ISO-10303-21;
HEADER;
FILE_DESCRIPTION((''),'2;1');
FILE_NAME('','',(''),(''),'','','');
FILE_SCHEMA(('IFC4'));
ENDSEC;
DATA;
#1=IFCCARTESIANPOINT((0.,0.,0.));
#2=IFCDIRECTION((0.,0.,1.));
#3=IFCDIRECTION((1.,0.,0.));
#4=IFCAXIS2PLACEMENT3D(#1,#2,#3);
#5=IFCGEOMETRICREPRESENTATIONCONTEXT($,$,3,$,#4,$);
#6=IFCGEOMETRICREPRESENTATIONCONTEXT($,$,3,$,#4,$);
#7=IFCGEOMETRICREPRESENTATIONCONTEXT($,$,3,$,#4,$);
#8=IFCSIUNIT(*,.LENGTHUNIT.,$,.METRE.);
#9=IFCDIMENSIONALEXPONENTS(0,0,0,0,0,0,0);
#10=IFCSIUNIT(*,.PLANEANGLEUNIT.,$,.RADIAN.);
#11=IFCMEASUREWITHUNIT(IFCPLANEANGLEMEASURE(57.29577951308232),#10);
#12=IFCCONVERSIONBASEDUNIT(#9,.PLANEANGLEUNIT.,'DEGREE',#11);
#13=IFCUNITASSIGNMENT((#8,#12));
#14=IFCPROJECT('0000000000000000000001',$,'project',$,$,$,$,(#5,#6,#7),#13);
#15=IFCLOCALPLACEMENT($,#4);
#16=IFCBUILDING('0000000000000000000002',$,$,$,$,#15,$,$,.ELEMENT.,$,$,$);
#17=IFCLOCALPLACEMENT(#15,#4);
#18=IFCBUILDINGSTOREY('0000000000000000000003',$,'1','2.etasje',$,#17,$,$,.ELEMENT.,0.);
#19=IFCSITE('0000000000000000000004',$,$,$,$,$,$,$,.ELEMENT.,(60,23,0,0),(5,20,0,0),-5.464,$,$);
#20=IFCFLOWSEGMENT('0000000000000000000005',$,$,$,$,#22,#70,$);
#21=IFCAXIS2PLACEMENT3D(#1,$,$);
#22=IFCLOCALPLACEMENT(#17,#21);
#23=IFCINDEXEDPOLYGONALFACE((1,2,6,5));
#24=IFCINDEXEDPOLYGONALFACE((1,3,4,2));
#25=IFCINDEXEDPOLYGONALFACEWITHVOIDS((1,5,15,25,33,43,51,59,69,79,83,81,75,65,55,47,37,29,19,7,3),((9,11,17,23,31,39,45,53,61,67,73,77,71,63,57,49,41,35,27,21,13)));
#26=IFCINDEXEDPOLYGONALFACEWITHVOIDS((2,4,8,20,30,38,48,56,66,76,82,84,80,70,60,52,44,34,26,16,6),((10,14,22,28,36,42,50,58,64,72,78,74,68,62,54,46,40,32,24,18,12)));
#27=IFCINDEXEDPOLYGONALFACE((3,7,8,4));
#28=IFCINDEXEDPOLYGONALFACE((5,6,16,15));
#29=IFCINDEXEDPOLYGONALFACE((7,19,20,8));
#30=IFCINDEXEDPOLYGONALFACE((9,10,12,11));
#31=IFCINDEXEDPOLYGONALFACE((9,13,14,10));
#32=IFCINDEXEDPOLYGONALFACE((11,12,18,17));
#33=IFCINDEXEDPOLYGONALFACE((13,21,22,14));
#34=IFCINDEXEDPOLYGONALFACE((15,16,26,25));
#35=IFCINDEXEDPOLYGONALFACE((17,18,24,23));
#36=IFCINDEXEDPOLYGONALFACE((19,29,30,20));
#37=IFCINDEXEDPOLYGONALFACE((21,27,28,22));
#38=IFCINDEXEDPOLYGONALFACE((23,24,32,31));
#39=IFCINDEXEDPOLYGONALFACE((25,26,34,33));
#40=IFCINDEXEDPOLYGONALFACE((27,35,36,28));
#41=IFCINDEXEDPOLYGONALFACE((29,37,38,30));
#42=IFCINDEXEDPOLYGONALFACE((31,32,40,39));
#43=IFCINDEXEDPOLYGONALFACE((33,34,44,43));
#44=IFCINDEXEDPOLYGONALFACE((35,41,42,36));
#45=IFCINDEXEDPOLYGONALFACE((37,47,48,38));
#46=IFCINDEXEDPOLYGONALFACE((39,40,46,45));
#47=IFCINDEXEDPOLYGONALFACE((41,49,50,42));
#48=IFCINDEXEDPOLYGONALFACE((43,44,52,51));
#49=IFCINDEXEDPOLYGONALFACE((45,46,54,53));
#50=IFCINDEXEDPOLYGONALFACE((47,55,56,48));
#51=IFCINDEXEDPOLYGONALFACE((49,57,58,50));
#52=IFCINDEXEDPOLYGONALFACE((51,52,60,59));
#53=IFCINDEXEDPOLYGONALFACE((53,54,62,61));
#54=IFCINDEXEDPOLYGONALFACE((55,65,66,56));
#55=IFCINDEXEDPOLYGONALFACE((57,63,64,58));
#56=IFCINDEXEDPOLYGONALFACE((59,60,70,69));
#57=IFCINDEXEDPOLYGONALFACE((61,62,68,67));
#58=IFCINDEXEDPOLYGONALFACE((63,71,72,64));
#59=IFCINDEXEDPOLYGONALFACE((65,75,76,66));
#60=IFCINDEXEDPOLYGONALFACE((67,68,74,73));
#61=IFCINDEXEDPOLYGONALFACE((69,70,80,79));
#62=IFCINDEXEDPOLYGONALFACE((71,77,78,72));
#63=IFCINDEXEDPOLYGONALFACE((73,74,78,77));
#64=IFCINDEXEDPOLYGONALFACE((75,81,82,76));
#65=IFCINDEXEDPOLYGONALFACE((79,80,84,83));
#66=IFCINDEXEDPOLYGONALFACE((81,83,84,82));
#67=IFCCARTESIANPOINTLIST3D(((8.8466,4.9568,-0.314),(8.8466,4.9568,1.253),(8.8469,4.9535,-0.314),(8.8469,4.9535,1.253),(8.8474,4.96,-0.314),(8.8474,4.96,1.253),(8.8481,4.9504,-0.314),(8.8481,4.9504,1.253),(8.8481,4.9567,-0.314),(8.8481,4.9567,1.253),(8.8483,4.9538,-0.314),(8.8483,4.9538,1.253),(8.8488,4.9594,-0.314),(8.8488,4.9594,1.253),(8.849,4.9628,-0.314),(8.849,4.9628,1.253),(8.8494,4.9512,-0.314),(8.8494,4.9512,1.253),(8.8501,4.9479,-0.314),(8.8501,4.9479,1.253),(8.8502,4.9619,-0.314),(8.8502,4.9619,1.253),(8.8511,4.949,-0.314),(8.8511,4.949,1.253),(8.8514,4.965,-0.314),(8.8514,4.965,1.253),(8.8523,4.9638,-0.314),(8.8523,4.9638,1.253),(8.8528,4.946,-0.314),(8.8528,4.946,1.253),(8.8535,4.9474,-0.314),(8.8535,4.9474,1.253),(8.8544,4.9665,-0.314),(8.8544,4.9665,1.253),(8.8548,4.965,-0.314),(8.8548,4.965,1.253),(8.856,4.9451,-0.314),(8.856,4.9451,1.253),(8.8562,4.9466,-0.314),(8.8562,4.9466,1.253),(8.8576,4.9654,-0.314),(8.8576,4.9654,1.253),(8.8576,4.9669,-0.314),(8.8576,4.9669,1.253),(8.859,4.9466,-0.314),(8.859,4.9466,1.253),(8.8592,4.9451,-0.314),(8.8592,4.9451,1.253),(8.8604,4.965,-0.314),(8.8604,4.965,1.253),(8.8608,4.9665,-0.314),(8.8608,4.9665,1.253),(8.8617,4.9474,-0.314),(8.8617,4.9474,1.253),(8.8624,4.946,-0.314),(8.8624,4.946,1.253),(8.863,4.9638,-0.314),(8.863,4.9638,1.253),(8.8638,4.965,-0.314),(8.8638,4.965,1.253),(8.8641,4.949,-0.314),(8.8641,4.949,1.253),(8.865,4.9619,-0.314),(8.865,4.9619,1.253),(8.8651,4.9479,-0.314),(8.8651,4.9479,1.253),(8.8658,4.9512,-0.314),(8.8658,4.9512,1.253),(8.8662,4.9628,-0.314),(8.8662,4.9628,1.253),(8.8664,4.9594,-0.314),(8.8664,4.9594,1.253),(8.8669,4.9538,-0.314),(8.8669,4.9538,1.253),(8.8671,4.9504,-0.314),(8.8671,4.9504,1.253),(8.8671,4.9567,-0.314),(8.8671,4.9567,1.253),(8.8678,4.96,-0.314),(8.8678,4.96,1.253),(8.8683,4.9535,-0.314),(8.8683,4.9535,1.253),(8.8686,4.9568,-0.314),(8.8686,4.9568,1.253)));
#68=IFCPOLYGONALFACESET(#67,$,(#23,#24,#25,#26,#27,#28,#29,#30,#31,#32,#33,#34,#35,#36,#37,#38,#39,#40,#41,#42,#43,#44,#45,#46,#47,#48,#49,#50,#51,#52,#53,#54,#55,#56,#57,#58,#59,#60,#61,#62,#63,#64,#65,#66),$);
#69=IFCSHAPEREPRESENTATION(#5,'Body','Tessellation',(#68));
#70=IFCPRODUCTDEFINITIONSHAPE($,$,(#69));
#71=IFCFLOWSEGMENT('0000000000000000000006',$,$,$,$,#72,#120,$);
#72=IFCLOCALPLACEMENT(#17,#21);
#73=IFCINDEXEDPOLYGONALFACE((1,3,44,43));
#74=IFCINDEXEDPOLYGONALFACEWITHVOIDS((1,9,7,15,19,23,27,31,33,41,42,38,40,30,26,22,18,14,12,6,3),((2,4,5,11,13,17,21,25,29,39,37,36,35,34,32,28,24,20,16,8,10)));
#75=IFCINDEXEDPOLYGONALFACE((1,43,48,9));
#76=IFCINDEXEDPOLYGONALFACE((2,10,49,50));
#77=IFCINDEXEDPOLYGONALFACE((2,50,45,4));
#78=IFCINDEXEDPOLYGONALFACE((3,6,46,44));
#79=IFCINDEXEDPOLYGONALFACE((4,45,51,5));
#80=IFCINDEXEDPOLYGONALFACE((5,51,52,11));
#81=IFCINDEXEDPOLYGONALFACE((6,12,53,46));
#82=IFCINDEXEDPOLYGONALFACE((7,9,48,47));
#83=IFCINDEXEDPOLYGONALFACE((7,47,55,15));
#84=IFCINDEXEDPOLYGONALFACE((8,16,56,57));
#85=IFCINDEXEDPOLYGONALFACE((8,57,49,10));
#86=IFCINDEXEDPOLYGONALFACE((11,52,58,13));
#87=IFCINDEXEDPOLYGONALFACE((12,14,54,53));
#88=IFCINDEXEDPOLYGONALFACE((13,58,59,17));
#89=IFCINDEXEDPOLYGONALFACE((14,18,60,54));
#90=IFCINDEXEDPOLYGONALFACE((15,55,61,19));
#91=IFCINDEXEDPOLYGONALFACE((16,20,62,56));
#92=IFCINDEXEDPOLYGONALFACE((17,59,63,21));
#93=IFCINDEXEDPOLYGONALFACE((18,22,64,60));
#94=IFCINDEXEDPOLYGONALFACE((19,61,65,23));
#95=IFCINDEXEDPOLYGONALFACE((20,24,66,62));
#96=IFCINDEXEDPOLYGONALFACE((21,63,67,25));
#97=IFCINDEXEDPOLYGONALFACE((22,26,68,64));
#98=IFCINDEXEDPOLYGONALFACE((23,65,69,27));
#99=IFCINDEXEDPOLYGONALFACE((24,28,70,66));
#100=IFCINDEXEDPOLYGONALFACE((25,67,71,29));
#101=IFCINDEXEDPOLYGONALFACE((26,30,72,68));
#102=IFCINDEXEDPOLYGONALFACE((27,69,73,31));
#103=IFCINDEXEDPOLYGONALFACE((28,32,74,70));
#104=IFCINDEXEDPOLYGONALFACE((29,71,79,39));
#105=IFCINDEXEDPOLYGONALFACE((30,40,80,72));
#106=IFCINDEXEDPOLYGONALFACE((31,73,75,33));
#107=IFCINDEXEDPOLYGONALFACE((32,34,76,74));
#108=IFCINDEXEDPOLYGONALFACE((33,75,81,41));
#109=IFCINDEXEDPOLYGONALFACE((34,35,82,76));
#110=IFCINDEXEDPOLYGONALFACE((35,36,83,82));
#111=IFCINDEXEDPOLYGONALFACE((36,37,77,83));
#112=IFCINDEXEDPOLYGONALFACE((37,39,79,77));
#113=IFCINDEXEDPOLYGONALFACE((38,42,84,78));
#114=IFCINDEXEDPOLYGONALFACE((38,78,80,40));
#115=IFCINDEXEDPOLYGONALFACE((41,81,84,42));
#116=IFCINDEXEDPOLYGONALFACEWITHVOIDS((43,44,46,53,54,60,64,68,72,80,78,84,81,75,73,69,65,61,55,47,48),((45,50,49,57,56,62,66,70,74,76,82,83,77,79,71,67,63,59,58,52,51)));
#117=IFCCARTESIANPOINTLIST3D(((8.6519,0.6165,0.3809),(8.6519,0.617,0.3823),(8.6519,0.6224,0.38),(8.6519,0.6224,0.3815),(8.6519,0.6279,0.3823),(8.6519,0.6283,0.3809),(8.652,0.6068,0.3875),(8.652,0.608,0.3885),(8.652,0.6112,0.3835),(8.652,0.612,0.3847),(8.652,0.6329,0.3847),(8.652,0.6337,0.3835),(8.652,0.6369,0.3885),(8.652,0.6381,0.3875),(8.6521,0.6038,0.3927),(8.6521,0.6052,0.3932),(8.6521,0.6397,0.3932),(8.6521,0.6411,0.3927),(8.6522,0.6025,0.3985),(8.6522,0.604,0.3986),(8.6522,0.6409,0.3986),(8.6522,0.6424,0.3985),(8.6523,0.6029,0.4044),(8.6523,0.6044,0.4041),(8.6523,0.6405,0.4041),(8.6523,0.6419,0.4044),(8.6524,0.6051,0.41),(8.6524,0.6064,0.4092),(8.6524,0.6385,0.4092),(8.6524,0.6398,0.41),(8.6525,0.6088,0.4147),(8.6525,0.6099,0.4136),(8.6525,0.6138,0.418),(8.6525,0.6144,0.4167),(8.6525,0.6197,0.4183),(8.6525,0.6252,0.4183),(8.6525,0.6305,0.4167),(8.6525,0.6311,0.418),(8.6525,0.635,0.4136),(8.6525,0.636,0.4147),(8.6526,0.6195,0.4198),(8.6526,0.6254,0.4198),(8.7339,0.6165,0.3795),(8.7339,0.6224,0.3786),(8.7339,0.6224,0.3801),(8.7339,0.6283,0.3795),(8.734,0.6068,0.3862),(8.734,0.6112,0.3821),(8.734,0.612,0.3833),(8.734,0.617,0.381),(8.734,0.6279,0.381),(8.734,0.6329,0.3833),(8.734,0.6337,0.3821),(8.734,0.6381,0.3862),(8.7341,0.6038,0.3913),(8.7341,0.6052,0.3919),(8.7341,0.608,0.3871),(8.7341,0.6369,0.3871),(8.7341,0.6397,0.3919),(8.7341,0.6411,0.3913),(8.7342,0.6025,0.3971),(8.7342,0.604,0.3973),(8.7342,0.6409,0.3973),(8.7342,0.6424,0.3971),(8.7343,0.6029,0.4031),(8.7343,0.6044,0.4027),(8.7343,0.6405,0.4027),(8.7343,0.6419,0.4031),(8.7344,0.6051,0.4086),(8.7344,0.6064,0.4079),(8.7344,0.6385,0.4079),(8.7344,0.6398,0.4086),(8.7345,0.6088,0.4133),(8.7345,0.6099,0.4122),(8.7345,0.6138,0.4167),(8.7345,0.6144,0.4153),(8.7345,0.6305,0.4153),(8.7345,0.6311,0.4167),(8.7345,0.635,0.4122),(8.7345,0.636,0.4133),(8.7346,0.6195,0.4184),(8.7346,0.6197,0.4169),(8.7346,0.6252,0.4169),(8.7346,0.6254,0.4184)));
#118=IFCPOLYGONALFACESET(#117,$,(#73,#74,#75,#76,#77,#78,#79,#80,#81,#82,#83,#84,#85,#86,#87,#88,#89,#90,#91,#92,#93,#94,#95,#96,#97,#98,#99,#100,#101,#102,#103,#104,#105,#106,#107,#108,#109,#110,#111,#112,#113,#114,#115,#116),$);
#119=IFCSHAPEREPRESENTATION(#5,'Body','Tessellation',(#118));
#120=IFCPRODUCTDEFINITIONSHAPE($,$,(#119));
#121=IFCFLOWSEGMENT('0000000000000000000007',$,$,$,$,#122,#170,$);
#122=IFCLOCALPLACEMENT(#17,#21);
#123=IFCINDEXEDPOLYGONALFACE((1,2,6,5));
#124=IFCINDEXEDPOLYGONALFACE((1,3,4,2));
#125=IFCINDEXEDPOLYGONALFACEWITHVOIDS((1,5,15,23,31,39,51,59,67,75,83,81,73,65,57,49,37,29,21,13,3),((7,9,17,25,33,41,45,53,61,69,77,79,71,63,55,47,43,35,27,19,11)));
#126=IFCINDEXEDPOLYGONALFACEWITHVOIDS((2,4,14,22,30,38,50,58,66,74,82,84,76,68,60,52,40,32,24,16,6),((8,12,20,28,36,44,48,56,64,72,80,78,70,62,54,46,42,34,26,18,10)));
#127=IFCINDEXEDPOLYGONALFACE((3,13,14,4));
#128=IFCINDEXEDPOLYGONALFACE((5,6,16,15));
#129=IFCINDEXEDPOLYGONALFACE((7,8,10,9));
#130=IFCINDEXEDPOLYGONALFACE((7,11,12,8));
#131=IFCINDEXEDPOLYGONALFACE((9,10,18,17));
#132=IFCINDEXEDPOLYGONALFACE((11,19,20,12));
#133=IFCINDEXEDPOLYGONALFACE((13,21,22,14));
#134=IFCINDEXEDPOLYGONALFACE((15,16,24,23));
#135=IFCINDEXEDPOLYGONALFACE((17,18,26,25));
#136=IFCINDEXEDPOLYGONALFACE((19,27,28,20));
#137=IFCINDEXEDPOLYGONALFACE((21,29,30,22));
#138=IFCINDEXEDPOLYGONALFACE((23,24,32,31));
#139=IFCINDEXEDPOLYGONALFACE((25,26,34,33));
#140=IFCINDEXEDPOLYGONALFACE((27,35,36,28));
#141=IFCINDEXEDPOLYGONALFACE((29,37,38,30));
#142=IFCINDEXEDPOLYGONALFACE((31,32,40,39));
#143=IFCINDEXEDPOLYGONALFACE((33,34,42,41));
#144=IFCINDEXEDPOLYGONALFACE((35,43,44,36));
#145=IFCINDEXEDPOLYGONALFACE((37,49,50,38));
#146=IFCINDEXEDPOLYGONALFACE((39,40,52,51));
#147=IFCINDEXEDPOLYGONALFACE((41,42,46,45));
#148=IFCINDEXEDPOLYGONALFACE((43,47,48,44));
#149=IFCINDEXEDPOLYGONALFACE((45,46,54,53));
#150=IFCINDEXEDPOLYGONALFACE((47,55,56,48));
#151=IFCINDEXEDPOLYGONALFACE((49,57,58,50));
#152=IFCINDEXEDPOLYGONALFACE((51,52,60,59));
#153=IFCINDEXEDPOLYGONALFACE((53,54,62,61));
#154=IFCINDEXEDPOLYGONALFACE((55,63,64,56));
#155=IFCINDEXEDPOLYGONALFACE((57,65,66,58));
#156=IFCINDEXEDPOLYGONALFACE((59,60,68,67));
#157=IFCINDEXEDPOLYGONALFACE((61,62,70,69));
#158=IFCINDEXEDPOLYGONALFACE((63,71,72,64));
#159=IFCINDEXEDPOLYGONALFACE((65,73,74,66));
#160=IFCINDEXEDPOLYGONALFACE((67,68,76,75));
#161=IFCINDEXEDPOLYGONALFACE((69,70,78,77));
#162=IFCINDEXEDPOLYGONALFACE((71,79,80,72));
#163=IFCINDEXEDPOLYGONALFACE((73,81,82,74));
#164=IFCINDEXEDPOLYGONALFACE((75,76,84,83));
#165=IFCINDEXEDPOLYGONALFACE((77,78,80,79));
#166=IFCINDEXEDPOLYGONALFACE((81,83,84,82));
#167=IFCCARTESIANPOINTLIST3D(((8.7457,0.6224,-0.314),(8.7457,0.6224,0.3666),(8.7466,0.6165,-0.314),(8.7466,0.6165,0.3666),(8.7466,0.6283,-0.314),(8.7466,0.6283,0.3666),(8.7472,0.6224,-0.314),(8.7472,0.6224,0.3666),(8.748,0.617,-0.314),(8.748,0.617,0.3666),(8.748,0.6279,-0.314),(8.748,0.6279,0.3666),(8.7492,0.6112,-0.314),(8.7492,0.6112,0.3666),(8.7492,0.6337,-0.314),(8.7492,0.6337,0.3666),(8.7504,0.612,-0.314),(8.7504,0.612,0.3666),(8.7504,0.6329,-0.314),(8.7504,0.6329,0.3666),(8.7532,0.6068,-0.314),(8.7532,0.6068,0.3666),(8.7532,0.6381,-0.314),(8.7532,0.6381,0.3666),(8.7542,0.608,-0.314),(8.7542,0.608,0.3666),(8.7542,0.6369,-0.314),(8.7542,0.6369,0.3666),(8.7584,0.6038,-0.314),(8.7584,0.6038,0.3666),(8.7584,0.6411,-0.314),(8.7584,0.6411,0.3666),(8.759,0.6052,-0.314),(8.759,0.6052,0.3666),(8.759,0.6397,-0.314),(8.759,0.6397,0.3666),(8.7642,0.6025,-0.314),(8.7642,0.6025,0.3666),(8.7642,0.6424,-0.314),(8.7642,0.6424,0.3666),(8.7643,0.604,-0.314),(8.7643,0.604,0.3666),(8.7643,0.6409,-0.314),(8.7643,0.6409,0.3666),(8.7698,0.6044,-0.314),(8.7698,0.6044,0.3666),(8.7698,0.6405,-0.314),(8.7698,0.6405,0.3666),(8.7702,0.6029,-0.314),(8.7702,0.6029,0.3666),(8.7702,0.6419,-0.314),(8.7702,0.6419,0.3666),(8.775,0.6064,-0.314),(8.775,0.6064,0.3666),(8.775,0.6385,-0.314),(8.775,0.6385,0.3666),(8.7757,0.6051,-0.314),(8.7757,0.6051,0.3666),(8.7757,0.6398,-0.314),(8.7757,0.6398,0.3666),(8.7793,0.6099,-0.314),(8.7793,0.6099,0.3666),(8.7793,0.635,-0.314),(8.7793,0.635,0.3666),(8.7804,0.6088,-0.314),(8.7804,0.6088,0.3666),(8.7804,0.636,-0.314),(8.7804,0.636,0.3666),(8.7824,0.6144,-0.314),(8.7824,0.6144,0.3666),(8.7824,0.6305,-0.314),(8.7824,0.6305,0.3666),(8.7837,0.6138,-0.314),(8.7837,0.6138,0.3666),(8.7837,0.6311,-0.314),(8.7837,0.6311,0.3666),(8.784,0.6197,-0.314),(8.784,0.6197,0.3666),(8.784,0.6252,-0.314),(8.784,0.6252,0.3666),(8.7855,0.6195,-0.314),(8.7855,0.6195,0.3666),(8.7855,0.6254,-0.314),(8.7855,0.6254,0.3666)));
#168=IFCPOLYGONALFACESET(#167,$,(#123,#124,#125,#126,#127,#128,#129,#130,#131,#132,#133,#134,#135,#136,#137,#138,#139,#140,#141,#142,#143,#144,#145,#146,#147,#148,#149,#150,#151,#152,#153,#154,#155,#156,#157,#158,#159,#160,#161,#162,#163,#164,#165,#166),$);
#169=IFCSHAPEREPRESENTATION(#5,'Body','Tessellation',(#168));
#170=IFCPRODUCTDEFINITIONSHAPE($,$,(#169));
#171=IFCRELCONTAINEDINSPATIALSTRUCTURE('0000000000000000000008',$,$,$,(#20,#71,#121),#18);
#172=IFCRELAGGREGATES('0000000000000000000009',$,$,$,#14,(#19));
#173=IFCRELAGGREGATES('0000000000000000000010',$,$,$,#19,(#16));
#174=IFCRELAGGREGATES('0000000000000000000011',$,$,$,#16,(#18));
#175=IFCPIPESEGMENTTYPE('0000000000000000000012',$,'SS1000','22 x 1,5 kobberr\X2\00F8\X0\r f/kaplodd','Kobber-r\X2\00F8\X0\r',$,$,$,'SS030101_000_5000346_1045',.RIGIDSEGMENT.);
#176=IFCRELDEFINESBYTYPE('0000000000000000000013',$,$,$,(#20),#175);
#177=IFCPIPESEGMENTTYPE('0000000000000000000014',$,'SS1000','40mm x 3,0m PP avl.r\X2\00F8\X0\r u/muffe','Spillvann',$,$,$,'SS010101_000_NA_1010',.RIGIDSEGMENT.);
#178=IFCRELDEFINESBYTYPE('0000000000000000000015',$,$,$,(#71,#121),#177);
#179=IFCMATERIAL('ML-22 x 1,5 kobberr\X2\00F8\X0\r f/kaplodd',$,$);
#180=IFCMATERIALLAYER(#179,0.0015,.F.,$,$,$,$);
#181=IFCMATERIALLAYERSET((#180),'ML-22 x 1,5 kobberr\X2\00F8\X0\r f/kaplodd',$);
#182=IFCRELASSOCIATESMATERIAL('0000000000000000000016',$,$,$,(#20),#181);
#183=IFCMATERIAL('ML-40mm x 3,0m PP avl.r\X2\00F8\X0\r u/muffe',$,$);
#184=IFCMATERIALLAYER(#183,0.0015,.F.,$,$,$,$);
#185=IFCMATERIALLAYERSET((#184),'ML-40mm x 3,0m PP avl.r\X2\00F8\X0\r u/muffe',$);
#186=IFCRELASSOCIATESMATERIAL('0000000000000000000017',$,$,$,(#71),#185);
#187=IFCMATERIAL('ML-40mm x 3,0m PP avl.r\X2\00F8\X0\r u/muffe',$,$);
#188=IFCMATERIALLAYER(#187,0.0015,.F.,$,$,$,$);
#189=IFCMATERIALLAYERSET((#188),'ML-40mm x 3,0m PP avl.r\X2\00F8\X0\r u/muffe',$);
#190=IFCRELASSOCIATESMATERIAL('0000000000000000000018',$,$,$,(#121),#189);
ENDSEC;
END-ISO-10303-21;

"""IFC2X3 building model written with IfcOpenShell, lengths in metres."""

from ifc_helpers import new_model, entity, si_unit, converted_unit, frame, origin_with_axes, origin_2d_with_axis, place, context, project, spatial, hollow_circle, extrude, material, layer, layer_set, layer_usage, type_object, element, save


model = new_model("IFC2X3")

# Units and contexts
context_of_model_1 = context(None, 3, world=origin_with_axes())
context_of_model_2 = context(None, 3, world=origin_with_axes())
context_of_model_3 = context(None, 3, world=origin_with_axes())
ifc_project = project(units=[si_unit("LENGTHUNIT", "METRE"), converted_unit("PLANEANGLEUNIT", "DEGREE", entity("IfcPlaneAngleMeasure", 57.29577951308232), si_unit("PLANEANGLEUNIT", "RADIAN"), dimensions=[0, 0, 0, 0, 0, 0, 0])], contexts=[context_of_model_1, context_of_model_2, context_of_model_3])

# Site, building, storey
site = spatial("IfcSite", under=ifc_project, CompositionType="ELEMENT", RefLatitude=(60, 23, 0, 0), RefLongitude=(5, 20, 0, 0), RefElevation=-5.464)
building_placement = place(None, origin_with_axes())
building = spatial("IfcBuilding", under=site, at=building_placement, CompositionType="ELEMENT")
storey_placement = place(building_placement, origin_with_axes())
storey = spatial("IfcBuildingStorey", under=building, at=storey_placement, Name="1", Description="2.etasje", CompositionType="ELEMENT", Elevation=0.0)

# Flow segments
pipe_segment_type_1 = type_object("IfcPipeSegmentType", Name="SS1000", Description="22 x 1,5 kobberrør f/kaplodd", ApplicableOccurrence="Kobber-rør", ElementType="SS030101_000_5000346_1045", PredefinedType="RIGIDSEGMENT")
ifc_material_1 = material(Name="ML-22 x 1,5 kobberrør f/kaplodd")
ifc_layer_1 = layer(ifc_material_1, 0.0015, ventilated=False)
ifc_layer_set_1 = layer_set([ifc_layer_1], Name="ML-22 x 1,5 kobberrør f/kaplodd")
ifc_layer_usage_1 = layer_usage(ifc_layer_set_1, "AXIS2", "POSITIVE", 0.0)
flow_segment_1_placement = place(storey_placement, frame((8.8576, 4.9559, 1.253), z_axis=(0.0, 0.0, -1.0), x_axis=(0.0, 1.0, 0.0)))
element("IfcFlowSegment", 1, at=flow_segment_1_placement, inside=storey, type_object=pipe_segment_type_1, material=ifc_layer_usage_1, context=context_of_model_1, shape_type="SweptSolid", body=[
    extrude(hollow_circle(Radius=0.011, WallThickness=0.0015, at=origin_2d_with_axis()), origin_with_axes(), (0.0, 0.0, 1.0), 1.567),
])
ifc_material_2 = material(Name="ML-40mm x 3,0m PP avl.rør u/muffe")
ifc_layer_2 = layer(ifc_material_2, 0.0015, ventilated=False)
ifc_layer_set_2 = layer_set([ifc_layer_2], Name="ML-40mm x 3,0m PP avl.rør u/muffe")
ifc_layer_usage_2 = layer_usage(ifc_layer_set_2, "AXIS2", "POSITIVE", 0.0)
pipe_segment_type_2 = type_object("IfcPipeSegmentType", Name="SS1000", Description="40mm x 3,0m PP avl.rør u/muffe", ApplicableOccurrence="Spillvann", ElementType="SS010101_000_NA_1010", PredefinedType="RIGIDSEGMENT")
flow_segment_2_placement = place(storey_placement, frame((8.6522, 0.6224, 0.4), z_axis=(0.999861, 0.0, -0.016664), x_axis=(-0.016664, 0.0, -0.999861)))
element("IfcFlowSegment", 2, at=flow_segment_2_placement, inside=storey, type_object=pipe_segment_type_2, material=ifc_layer_usage_2, context=context_of_model_1, shape_type="SweptSolid", body=[
    extrude(hollow_circle(Radius=0.02, WallThickness=0.0015, at=origin_2d_with_axis()), origin_with_axes(), (0.0, 0.0, 1.0), 0.082),
])
ifc_material_3 = material(Name="ML-40mm x 3,0m PP avl.rør u/muffe")
ifc_layer_3 = layer(ifc_material_3, 0.0015, ventilated=False)
ifc_layer_set_3 = layer_set([ifc_layer_3], Name="ML-40mm x 3,0m PP avl.rør u/muffe")
ifc_layer_usage_3 = layer_usage(ifc_layer_set_3, "AXIS2", "POSITIVE", 0.0)
flow_segment_3_placement = place(storey_placement, frame((8.7657, 0.6224, 0.3666), z_axis=(0.0, 0.0, -1.0), x_axis=(-1.0, 0.0, 0.0)))
element("IfcFlowSegment", 3, at=flow_segment_3_placement, inside=storey, type_object=pipe_segment_type_2, material=ifc_layer_usage_3, context=context_of_model_1, shape_type="SweptSolid", body=[
    extrude(hollow_circle(Radius=0.02, WallThickness=0.0015, at=origin_2d_with_axis()), origin_with_axes(), (0.0, 0.0, 1.0), 0.6806),
])

save(model, "model.ifc")
